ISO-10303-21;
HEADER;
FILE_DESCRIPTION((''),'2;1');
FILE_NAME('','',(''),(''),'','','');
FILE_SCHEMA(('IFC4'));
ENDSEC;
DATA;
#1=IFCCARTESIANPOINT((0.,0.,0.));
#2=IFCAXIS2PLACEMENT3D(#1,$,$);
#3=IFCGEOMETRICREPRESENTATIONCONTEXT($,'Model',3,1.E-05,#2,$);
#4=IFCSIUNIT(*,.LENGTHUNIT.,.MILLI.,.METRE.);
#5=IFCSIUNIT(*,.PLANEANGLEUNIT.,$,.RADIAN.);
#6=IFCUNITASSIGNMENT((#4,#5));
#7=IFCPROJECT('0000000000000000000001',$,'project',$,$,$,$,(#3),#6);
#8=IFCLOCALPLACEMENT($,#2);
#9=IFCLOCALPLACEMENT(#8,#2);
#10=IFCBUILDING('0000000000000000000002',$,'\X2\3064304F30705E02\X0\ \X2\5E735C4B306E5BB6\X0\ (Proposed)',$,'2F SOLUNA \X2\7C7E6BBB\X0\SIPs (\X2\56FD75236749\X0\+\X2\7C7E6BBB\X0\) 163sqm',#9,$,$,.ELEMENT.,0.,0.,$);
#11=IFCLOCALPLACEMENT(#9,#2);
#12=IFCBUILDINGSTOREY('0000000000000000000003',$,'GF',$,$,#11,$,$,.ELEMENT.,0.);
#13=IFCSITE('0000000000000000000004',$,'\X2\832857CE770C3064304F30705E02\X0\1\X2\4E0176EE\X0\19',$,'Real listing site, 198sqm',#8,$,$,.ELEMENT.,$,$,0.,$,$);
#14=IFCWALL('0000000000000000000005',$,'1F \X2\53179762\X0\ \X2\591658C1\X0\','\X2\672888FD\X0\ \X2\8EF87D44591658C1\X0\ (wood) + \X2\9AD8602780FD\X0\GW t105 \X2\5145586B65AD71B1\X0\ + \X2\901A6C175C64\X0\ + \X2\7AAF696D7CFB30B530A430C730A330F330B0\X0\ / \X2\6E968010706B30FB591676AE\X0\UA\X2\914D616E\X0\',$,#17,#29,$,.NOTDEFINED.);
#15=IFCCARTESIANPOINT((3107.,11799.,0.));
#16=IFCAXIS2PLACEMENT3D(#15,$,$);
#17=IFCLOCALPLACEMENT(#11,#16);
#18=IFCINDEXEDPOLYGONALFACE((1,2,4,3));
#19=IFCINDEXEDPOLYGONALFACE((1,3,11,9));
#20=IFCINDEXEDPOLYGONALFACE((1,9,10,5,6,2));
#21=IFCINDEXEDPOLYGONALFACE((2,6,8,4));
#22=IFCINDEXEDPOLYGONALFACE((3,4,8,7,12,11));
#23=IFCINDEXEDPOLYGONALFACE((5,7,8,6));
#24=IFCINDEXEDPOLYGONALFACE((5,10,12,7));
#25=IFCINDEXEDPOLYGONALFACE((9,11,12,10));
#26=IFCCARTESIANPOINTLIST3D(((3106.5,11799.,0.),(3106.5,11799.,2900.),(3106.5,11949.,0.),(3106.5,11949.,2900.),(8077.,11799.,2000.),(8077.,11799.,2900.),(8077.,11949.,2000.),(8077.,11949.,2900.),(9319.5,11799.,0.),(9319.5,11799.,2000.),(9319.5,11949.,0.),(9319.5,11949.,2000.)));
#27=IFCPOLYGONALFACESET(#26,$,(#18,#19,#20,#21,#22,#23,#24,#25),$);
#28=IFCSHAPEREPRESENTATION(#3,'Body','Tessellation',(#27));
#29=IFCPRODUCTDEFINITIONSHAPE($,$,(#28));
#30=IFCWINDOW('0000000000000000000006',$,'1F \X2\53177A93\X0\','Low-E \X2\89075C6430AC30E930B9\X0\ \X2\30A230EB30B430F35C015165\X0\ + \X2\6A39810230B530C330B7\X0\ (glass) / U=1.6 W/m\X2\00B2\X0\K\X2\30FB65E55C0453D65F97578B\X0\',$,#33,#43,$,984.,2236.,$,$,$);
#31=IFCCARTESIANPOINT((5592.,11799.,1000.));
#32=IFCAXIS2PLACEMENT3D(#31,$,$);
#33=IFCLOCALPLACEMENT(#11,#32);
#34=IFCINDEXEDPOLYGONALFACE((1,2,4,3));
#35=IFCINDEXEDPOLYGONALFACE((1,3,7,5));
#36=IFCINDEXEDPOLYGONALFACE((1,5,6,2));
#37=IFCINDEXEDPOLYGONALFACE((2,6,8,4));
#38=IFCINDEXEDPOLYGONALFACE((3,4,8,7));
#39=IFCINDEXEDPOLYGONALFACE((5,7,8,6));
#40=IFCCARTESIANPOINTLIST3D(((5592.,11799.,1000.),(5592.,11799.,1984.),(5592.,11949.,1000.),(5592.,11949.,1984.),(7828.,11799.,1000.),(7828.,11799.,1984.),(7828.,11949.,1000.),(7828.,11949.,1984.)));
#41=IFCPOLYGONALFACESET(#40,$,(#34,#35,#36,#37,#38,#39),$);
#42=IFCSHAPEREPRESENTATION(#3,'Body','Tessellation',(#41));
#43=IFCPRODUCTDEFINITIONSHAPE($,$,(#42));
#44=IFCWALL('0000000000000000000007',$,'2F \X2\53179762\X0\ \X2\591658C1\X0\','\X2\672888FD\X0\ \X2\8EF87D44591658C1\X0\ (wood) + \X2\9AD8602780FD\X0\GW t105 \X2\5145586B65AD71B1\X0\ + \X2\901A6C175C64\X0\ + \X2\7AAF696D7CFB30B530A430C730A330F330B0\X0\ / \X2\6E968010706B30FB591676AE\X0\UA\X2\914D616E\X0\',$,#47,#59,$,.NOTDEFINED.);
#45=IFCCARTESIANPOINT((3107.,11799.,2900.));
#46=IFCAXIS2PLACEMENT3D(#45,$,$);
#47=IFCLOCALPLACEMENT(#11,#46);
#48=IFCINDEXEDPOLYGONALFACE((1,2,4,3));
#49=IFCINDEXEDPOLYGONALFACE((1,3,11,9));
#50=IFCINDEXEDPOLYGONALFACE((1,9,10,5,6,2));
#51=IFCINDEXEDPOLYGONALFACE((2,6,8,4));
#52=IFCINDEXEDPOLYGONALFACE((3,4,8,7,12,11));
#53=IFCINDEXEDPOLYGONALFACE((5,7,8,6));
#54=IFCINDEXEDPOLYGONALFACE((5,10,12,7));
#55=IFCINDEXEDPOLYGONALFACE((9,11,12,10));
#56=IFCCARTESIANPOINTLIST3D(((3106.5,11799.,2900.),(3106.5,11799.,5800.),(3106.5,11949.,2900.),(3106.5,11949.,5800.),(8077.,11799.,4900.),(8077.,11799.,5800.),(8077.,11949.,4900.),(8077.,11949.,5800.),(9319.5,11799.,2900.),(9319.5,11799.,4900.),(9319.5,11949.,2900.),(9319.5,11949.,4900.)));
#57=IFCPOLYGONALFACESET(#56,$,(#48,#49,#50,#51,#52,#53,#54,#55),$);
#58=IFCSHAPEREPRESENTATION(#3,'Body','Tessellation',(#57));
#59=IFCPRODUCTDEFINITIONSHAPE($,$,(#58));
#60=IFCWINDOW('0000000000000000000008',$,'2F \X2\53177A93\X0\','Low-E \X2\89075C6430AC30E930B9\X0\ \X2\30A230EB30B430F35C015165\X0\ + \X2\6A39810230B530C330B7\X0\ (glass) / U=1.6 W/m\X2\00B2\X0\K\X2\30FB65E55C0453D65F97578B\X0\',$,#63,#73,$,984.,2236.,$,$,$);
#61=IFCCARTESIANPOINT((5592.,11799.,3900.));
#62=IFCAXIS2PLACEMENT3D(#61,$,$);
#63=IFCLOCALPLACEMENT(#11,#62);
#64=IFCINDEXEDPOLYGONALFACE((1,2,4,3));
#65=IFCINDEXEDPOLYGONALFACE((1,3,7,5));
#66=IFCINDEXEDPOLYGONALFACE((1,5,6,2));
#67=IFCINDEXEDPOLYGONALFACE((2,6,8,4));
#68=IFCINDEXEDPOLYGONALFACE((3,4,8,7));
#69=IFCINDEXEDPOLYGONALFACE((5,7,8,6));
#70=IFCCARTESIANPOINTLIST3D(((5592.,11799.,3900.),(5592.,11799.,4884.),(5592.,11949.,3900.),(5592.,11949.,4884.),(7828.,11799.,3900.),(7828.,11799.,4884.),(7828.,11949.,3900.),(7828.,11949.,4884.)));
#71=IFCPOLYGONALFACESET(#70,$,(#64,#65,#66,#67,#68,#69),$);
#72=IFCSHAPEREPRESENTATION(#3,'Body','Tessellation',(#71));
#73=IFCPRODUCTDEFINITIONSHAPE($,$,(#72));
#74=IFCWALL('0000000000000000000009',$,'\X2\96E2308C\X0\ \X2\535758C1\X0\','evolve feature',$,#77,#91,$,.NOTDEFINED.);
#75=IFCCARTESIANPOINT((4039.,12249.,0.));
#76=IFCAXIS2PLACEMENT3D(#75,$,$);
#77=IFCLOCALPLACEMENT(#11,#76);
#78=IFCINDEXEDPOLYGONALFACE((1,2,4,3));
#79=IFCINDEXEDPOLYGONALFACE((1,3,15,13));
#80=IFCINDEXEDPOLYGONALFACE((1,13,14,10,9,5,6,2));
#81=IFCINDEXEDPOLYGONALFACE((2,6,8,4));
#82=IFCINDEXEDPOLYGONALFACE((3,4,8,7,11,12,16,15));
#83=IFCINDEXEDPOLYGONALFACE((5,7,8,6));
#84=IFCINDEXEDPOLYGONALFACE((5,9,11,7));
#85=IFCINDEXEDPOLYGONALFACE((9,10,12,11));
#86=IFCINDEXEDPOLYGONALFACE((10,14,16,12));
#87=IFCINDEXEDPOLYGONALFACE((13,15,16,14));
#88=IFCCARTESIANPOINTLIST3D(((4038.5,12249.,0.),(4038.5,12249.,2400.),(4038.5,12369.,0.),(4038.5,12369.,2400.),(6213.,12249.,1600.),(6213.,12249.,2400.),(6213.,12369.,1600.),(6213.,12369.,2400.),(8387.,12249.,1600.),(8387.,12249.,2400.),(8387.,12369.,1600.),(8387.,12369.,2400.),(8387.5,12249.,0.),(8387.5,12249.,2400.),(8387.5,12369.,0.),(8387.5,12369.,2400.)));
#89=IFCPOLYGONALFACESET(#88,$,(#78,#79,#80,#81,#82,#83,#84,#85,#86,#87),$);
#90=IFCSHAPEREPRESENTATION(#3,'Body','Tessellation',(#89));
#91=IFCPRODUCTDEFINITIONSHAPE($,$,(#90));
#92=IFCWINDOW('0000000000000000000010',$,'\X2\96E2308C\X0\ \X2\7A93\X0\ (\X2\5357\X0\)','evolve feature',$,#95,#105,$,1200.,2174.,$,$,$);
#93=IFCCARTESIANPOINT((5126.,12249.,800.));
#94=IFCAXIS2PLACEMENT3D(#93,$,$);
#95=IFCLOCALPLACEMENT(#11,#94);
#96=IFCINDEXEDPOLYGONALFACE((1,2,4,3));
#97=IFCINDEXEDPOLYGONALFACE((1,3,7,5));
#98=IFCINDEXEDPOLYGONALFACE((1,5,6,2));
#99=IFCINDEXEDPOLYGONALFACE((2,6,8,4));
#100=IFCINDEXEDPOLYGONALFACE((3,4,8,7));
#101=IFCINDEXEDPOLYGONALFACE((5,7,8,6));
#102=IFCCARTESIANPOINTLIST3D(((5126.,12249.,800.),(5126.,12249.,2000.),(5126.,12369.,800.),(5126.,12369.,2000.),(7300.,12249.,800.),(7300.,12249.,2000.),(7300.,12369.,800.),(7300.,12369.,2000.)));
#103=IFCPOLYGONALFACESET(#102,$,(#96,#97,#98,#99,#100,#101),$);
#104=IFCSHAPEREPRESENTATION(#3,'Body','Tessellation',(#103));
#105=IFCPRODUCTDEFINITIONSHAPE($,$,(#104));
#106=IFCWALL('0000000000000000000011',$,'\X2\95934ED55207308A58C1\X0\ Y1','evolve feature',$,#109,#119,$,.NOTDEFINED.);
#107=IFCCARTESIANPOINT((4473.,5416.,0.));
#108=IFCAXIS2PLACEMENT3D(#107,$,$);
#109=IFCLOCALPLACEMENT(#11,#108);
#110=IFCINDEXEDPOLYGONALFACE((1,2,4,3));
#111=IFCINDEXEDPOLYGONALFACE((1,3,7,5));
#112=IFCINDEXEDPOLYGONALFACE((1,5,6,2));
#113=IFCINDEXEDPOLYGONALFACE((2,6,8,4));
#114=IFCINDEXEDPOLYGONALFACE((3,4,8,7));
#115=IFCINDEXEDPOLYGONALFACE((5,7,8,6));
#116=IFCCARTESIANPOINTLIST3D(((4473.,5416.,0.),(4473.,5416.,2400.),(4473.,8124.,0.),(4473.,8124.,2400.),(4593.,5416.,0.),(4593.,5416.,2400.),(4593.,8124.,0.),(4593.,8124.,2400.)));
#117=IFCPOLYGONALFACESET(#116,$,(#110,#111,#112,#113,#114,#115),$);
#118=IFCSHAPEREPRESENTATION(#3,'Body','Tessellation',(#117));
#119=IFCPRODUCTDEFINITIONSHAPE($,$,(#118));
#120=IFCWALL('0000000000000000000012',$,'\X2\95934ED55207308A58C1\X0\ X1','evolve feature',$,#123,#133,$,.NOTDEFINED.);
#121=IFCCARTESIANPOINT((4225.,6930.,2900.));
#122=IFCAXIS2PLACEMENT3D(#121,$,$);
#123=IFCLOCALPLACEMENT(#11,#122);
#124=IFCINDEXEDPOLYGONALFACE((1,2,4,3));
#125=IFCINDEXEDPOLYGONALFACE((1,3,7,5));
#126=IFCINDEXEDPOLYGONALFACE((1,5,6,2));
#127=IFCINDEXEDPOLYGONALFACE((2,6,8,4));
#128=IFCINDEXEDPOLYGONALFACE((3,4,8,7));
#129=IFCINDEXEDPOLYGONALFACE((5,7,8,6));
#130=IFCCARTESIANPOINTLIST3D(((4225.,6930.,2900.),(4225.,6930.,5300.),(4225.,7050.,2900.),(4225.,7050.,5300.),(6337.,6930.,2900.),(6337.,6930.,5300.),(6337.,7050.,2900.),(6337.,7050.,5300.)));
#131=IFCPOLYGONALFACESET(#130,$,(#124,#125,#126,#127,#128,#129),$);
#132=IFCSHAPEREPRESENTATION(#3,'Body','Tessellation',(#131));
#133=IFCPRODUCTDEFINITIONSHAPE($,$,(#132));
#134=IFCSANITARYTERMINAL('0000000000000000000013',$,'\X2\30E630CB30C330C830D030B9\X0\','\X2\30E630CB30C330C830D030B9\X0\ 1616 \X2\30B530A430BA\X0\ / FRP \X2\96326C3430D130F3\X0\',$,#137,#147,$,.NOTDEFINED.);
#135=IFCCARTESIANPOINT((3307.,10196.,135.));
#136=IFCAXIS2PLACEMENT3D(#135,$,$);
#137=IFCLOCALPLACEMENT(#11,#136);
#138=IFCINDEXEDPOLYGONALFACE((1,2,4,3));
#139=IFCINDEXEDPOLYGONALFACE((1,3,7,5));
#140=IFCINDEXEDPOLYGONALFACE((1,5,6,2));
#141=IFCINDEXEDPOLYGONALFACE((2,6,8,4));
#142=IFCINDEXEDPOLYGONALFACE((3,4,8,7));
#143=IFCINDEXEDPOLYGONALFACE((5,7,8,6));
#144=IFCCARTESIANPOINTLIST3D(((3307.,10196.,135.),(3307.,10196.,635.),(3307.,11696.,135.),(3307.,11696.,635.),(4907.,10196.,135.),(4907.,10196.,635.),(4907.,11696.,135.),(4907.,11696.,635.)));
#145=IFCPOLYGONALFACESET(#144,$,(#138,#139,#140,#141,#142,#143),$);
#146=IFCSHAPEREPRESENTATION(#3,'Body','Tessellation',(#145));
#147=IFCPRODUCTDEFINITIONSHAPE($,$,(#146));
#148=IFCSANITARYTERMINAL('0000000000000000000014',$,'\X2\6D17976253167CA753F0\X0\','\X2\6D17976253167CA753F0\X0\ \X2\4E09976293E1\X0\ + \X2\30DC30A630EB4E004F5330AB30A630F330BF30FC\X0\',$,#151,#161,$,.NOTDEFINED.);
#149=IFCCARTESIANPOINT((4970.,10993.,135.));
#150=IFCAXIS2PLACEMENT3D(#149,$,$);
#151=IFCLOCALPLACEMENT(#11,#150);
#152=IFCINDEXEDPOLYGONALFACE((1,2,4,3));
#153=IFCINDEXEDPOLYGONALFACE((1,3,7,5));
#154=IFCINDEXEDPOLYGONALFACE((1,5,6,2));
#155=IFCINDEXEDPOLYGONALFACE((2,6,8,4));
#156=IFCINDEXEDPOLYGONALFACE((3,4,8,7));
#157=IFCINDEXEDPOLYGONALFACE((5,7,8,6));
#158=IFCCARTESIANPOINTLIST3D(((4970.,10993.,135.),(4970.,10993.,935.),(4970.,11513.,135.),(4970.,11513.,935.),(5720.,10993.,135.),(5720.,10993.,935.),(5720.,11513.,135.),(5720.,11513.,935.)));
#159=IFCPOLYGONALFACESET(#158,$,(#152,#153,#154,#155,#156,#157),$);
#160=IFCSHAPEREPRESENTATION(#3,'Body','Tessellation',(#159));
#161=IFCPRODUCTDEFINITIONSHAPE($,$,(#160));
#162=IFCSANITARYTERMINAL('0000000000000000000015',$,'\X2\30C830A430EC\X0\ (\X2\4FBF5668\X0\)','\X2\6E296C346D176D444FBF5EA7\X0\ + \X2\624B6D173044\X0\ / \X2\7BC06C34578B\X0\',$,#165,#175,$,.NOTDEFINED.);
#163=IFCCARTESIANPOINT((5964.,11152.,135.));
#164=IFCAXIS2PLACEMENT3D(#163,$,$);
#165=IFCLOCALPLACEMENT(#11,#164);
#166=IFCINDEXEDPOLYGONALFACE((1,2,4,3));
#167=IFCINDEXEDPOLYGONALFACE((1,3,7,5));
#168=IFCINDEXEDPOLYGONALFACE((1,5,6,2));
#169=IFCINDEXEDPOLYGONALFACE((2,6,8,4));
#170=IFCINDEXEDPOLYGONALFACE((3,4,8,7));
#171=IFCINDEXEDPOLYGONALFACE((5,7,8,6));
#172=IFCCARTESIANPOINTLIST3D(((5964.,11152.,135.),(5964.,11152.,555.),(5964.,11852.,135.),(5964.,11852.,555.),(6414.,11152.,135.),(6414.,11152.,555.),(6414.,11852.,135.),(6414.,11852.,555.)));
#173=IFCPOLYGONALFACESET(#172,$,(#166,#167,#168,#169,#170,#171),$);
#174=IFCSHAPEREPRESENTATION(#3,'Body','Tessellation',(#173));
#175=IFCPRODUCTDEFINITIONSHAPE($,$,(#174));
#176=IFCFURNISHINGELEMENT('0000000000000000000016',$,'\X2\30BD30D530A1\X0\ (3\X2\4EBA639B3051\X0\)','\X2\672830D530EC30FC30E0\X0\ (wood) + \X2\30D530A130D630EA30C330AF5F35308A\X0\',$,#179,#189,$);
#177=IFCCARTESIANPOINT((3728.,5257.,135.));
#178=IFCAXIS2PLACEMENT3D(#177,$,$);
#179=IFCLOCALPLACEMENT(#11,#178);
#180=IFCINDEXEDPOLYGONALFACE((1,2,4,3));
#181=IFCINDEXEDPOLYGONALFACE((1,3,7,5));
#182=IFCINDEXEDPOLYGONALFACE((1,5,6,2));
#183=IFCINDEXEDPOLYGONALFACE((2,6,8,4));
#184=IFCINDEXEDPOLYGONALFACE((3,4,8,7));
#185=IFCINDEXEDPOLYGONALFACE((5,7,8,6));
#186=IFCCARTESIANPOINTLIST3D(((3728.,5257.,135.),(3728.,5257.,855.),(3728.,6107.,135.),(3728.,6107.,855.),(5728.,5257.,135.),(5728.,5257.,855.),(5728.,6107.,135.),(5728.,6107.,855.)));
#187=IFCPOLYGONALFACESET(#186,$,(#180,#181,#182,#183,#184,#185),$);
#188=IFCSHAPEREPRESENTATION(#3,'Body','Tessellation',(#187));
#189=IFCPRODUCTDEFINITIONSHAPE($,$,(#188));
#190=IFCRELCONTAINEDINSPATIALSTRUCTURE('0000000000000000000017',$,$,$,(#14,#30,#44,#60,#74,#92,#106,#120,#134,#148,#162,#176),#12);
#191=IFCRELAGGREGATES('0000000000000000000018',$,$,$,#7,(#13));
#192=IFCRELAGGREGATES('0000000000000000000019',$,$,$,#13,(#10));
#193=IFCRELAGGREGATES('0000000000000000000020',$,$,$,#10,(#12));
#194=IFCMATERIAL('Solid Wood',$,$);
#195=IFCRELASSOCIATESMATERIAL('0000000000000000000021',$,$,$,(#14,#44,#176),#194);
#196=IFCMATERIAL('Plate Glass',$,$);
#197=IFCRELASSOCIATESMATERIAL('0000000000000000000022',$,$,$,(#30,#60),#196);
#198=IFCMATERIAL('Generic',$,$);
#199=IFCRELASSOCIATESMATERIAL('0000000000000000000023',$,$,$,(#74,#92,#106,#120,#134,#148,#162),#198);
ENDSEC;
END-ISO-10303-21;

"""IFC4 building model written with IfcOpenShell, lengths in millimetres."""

from ifc_helpers import new_model, si_unit, frame, frame_2d, origin, place, context, project, spatial, rectangle, extrude, material, element, fill, save


model = new_model("IFC4")

# Units and contexts
model_context = context("Model", 3, precision=1e-05, world=origin())
ifc_project = project(units=[si_unit("LENGTHUNIT", "METRE", prefix="MILLI"), si_unit("PLANEANGLEUNIT", "RADIAN")], contexts=[model_context])

# Site, building, storey
site_placement = place(None, origin())
site = spatial("IfcSite", under=ifc_project, at=site_placement, Name="茨城県つくば市1丁目19", ObjectType="Real listing site, 198sqm", CompositionType="ELEMENT", RefElevation=0.0)
building_placement = place(site_placement, origin())
building = spatial("IfcBuilding", under=site, at=building_placement, Name="つくば市 平屋の家 (Proposed)", ObjectType="2F SOLUNA 籾殻SIPs (国産杉+籾殻) 163sqm", CompositionType="ELEMENT", ElevationOfRefHeight=0.0, ElevationOfTerrain=0.0)
storey_placement = place(building_placement, origin())
storey = spatial("IfcBuildingStorey", under=building, at=storey_placement, Name="GF", CompositionType="ELEMENT", Elevation=0.0)

# Shared definitions
ifc_material_1 = material(Name="Generic")

# Wall, opening, window
ifc_material_2 = material(Name="Solid Wood")
wall_1_placement = place(storey_placement, frame((3107.0, 11799.0, 0.0)))
wall_1 = element("IfcWall", 1, at=wall_1_placement, inside=storey, material=ifc_material_2, Name="1F 北面 外壁", Description="木製 軸組外壁 (wood) + 高性能GW t105 充填断熱 + 通気層 + 窯業系サイディング / 準耐火・外皮UA配慮", PredefinedType="NOTDEFINED", context=model_context, shape_type="SweptSolid", body=[
    extrude(rectangle(XDim=6213.0, YDim=150.0, at=frame_2d((3106.0, 75.0))), frame((3107.0, 11799.0, 0.0)), (0.0, 0.0, 1.0), 2900.0),
])
opening_1_placement = place(storey_placement, frame((5592.0, 11799.0, 1000.0)))
opening_1 = element("IfcOpeningElement", 2, at=opening_1_placement, cuts=wall_1, PredefinedType="NOTDEFINED", context=model_context, shape_type="SweptSolid", body=[
    extrude(rectangle(XDim=2236.0, YDim=150.0, at=frame_2d((1118.0, 75.0))), frame((5592.0, 11799.0, 1000.0)), (0.0, 0.0, 1.0), 984.0),
])
ifc_material_3 = material(Name="Plate Glass")
window_1_placement = place(storey_placement, frame((5592.0, 11799.0, 1000.0)))
window_1 = element("IfcWindow", 3, at=window_1_placement, inside=storey, material=ifc_material_3, Name="1F 北窓", Description="Low-E 複層ガラス アルゴン封入 + 樹脂サッシ (glass) / U=1.6 W/m²K・日射取得型", OverallHeight=984.0, OverallWidth=2236.0, context=model_context, shape_type="SweptSolid", body=[
    extrude(rectangle(XDim=2236.0, YDim=150.0, at=frame_2d((1118.0, 75.0))), frame((5592.0, 11799.0, 1000.0)), (0.0, 0.0, 1.0), 984.0),
])
fill(opening_1, window_1)

# Wall, opening, window
wall_2_placement = place(storey_placement, frame((3107.0, 11799.0, 2900.0)))
wall_2 = element("IfcWall", 4, at=wall_2_placement, inside=storey, material=ifc_material_2, Name="2F 北面 外壁", Description="木製 軸組外壁 (wood) + 高性能GW t105 充填断熱 + 通気層 + 窯業系サイディング / 準耐火・外皮UA配慮", PredefinedType="NOTDEFINED", context=model_context, shape_type="SweptSolid", body=[
    extrude(rectangle(XDim=6213.0, YDim=150.0, at=frame_2d((3106.0, 75.0))), frame((3107.0, 11799.0, 2900.0)), (0.0, 0.0, 1.0), 2900.0),
])
opening_2_placement = place(storey_placement, frame((5592.0, 11799.0, 3900.0)))
opening_2 = element("IfcOpeningElement", 5, at=opening_2_placement, cuts=wall_2, PredefinedType="NOTDEFINED", context=model_context, shape_type="SweptSolid", body=[
    extrude(rectangle(XDim=2236.0, YDim=150.0, at=frame_2d((1118.0, 75.0))), frame((5592.0, 11799.0, 3900.0)), (0.0, 0.0, 1.0), 984.0),
])
window_2_placement = place(storey_placement, frame((5592.0, 11799.0, 3900.0)))
window_2 = element("IfcWindow", 6, at=window_2_placement, inside=storey, material=ifc_material_3, Name="2F 北窓", Description="Low-E 複層ガラス アルゴン封入 + 樹脂サッシ (glass) / U=1.6 W/m²K・日射取得型", OverallHeight=984.0, OverallWidth=2236.0, context=model_context, shape_type="SweptSolid", body=[
    extrude(rectangle(XDim=2236.0, YDim=150.0, at=frame_2d((1118.0, 75.0))), frame((5592.0, 11799.0, 3900.0)), (0.0, 0.0, 1.0), 984.0),
])
fill(opening_2, window_2)

# Wall, opening, window
wall_3_placement = place(storey_placement, frame((4039.0, 12249.0, 0.0)))
wall_3 = element("IfcWall", 7, at=wall_3_placement, inside=storey, material=ifc_material_1, Name="離れ 南壁", Description="evolve feature", PredefinedType="NOTDEFINED", context=model_context, shape_type="SweptSolid", body=[
    extrude(rectangle(XDim=4349.0, YDim=120.0, at=frame_2d((2174.0, 60.0))), frame((4039.0, 12249.0, 0.0)), (0.0, 0.0, 1.0), 2400.0),
])
opening_3_placement = place(storey_placement, frame((5126.0, 12249.0, 800.0)))
opening_3 = element("IfcOpeningElement", 8, at=opening_3_placement, cuts=wall_3, PredefinedType="NOTDEFINED", context=model_context, shape_type="SweptSolid", body=[
    extrude(rectangle(XDim=2174.0, YDim=120.0, at=frame_2d((1087.0, 60.0))), frame((5126.0, 12249.0, 800.0)), (0.0, 0.0, 1.0), 1200.0),
])
window_3_placement = place(storey_placement, frame((5126.0, 12249.0, 800.0)))
window_3 = element("IfcWindow", 9, at=window_3_placement, inside=storey, material=ifc_material_1, Name="離れ 窓 (南)", Description="evolve feature", OverallHeight=1200.0, OverallWidth=2174.0, context=model_context, shape_type="SweptSolid", body=[
    extrude(rectangle(XDim=2174.0, YDim=120.0, at=frame_2d((1087.0, 60.0))), frame((5126.0, 12249.0, 800.0)), (0.0, 0.0, 1.0), 1200.0),
])
fill(opening_3, window_3)

# Walls
wall_4_placement = place(storey_placement, frame((4473.0, 5416.0, 0.0)))
element("IfcWall", 10, at=wall_4_placement, inside=storey, material=ifc_material_1, Name="間仕切り壁 Y1", Description="evolve feature", PredefinedType="NOTDEFINED", context=model_context, shape_type="SweptSolid", body=[
    extrude(rectangle(XDim=120.0, YDim=2708.0, at=frame_2d((60.0, 1354.0))), frame((4473.0, 5416.0, 0.0)), (0.0, 0.0, 1.0), 2400.0),
])
wall_5_placement = place(storey_placement, frame((4225.0, 6930.0, 2900.0)))
element("IfcWall", 11, at=wall_5_placement, inside=storey, material=ifc_material_1, Name="間仕切り壁 X1", Description="evolve feature", PredefinedType="NOTDEFINED", context=model_context, shape_type="SweptSolid", body=[
    extrude(rectangle(XDim=2112.0, YDim=120.0, at=frame_2d((1056.0, 60.0))), frame((4225.0, 6930.0, 2900.0)), (0.0, 0.0, 1.0), 2400.0),
])

# Sanitary terminals
sanitary_terminal_1_placement = place(storey_placement, frame((3307.0, 10196.0, 135.0)))
element("IfcSanitaryTerminal", 12, at=sanitary_terminal_1_placement, inside=storey, material=ifc_material_1, Name="ユニットバス", Description="ユニットバス 1616 サイズ / FRP 防水パン", PredefinedType="NOTDEFINED", context=model_context, shape_type="SweptSolid", body=[
    extrude(rectangle(XDim=1600.0, YDim=1500.0, at=frame_2d((800.0, 750.0))), frame((3307.0, 10196.0, 135.0)), (0.0, 0.0, 1.0), 500.0),
])
sanitary_terminal_2_placement = place(storey_placement, frame((4970.0, 10993.0, 135.0)))
element("IfcSanitaryTerminal", 13, at=sanitary_terminal_2_placement, inside=storey, material=ifc_material_1, Name="洗面化粧台", Description="洗面化粧台 三面鏡 + ボウル一体カウンター", PredefinedType="NOTDEFINED", context=model_context, shape_type="SweptSolid", body=[
    extrude(rectangle(XDim=750.0, YDim=520.0, at=frame_2d((375.0, 260.0))), frame((4970.0, 10993.0, 135.0)), (0.0, 0.0, 1.0), 800.0),
])
sanitary_terminal_3_placement = place(storey_placement, frame((5964.0, 11152.0, 135.0)))
element("IfcSanitaryTerminal", 14, at=sanitary_terminal_3_placement, inside=storey, material=ifc_material_1, Name="トイレ (便器)", Description="温水洗浄便座 + 手洗い / 節水型", PredefinedType="NOTDEFINED", context=model_context, shape_type="SweptSolid", body=[
    extrude(rectangle(XDim=450.0, YDim=700.0, at=frame_2d((225.0, 350.0))), frame((5964.0, 11152.0, 135.0)), (0.0, 0.0, 1.0), 420.0),
])

# Furnishing element
furnishing_1_placement = place(storey_placement, frame((3728.0, 5257.0, 135.0)))
element("IfcFurnishingElement", 15, at=furnishing_1_placement, inside=storey, material=ifc_material_2, Name="ソファ (3人掛け)", Description="木フレーム (wood) + ファブリック張り", context=model_context, shape_type="SweptSolid", body=[
    extrude(rectangle(XDim=2000.0, YDim=850.0, at=frame_2d((1000.0, 425.0))), frame((3728.0, 5257.0, 135.0)), (0.0, 0.0, 1.0), 720.0),
])

save(model, "model.ifc")
